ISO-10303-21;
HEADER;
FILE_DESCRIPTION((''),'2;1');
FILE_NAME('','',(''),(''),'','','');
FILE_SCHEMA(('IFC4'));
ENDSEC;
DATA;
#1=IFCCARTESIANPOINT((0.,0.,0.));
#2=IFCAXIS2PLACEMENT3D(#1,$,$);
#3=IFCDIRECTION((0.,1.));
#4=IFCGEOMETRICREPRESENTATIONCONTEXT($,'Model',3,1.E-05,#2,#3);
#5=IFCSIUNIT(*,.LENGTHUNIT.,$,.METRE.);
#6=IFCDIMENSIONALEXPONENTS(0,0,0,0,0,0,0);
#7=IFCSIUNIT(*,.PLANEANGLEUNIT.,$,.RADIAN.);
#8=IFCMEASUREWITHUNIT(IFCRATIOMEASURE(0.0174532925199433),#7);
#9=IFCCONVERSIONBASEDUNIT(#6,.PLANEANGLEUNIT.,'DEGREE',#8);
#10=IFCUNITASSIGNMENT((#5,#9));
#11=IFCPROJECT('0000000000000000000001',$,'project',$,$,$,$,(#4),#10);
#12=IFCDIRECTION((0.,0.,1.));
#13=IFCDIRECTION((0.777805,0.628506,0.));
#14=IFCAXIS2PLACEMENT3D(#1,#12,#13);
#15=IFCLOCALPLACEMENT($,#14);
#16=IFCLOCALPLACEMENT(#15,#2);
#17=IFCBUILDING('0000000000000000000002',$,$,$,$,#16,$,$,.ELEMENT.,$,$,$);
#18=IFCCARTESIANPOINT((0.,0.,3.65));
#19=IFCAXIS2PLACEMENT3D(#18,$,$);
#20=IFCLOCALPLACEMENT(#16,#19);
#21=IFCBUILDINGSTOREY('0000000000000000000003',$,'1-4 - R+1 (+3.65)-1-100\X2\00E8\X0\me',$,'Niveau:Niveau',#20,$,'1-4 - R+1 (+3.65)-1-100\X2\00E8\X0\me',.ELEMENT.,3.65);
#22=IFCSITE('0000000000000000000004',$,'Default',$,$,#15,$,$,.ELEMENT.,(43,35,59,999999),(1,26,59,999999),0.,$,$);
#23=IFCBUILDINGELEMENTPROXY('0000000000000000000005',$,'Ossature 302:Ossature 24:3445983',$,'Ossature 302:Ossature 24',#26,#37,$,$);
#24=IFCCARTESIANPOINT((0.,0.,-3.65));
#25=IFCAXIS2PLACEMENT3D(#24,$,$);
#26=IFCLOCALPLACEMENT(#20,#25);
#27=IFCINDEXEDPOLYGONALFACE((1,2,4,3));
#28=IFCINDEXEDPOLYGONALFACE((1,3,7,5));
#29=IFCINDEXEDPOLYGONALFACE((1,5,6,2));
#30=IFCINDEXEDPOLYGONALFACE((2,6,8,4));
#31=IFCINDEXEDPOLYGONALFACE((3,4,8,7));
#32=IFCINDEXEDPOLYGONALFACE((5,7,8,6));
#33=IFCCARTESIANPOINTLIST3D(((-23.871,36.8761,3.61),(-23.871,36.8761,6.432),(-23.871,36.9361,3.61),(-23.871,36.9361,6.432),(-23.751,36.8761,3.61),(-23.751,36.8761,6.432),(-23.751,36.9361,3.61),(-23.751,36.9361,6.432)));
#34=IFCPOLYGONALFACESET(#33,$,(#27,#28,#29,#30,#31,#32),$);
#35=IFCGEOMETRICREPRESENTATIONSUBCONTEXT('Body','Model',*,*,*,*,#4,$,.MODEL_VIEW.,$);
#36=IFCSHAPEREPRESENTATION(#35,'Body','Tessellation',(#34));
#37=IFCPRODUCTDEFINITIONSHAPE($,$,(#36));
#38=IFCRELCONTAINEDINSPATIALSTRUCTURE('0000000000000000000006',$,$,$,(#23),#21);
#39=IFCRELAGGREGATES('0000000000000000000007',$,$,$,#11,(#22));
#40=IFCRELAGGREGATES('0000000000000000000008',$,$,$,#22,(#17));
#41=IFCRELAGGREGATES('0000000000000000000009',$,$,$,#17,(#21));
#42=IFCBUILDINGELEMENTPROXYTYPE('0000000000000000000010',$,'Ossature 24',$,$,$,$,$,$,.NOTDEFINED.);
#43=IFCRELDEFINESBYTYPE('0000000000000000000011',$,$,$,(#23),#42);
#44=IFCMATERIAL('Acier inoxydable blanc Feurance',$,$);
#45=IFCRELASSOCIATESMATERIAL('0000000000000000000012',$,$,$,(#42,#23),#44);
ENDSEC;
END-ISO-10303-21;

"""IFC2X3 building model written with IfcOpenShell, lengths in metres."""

from ifc_helpers import new_model, entity, si_unit, converted_unit, direction, frame, frame_2d, origin, place, context, subcontext, project, spatial, rectangle, extrude, source, transform, mapped, material, type_object, type_shapes, element, save


model = new_model("IFC2X3")

# Units and contexts
model_context = context("Model", 3, precision=1e-05, world=origin(), true_north=direction((0.0, 1.0)))
body_context = subcontext(model_context, "Body", "Model", "MODEL_VIEW")
ifc_project = project(units=[si_unit("LENGTHUNIT", "METRE"), converted_unit("PLANEANGLEUNIT", "DEGREE", entity("IfcRatioMeasure", 0.0174532925199433), si_unit("PLANEANGLEUNIT", "RADIAN"), dimensions=[0, 0, 0, 0, 0, 0, 0])], contexts=[model_context])

# Site, building, storey
site_placement = place(None, frame((0.0, 0.0, 0.0), z_axis=(0.0, 0.0, 1.0), x_axis=(0.777805, 0.628506, 0.0)))
site = spatial("IfcSite", under=ifc_project, at=site_placement, Name="Default", CompositionType="ELEMENT", RefLatitude=(43, 35, 59, 999999), RefLongitude=(1, 26, 59, 999999), RefElevation=0.0)
building_placement = place(site_placement, origin())
building = spatial("IfcBuilding", under=site, at=building_placement, CompositionType="ELEMENT")
storey_placement = place(building_placement, frame((0.0, 0.0, 3.65)))
storey = spatial("IfcBuildingStorey", under=building, at=storey_placement, Name="1-4 - R+1 (+3.65)-1-100ème", ObjectType="Niveau:Niveau", LongName="1-4 - R+1 (+3.65)-1-100ème", CompositionType="ELEMENT", Elevation=3.65)

# Building element proxy
ifc_material_1 = material(Name="Acier inoxydable blanc Feurance")
building_element_proxy_type_1 = type_object("IfcBuildingElementProxyType", Name="Ossature 24", PredefinedType="NOTDEFINED", material=ifc_material_1)
shared_shape_1 = source(origin(), body_context, "Body", "SweptSolid", [
    extrude(rectangle(XDim=0.06, YDim=0.12, at=frame_2d((0.0, 0.0), x_axis=(1.0, 0.0))), frame((-23.811, 36.9061, 3.61), z_axis=(0.0, 0.0, 1.0), x_axis=(0.0, -1.0, 0.0)), (0.0, 0.0, 1.0), 2.822),
])
type_shapes(building_element_proxy_type_1, [shared_shape_1])
proxy_1_placement = place(storey_placement, frame((0.0, 0.0, -3.65)))
element("IfcBuildingElementProxy", 1, at=proxy_1_placement, inside=storey, type_object=building_element_proxy_type_1, material=ifc_material_1, Name="Ossature 302:Ossature 24:3445983", ObjectType="Ossature 302:Ossature 24", context=body_context, shape_type="MappedRepresentation", body=[
    mapped(shared_shape_1, transform((0.0, 0.0, 0.0), scale=1.0)),
])

save(model, "model.ifc")
